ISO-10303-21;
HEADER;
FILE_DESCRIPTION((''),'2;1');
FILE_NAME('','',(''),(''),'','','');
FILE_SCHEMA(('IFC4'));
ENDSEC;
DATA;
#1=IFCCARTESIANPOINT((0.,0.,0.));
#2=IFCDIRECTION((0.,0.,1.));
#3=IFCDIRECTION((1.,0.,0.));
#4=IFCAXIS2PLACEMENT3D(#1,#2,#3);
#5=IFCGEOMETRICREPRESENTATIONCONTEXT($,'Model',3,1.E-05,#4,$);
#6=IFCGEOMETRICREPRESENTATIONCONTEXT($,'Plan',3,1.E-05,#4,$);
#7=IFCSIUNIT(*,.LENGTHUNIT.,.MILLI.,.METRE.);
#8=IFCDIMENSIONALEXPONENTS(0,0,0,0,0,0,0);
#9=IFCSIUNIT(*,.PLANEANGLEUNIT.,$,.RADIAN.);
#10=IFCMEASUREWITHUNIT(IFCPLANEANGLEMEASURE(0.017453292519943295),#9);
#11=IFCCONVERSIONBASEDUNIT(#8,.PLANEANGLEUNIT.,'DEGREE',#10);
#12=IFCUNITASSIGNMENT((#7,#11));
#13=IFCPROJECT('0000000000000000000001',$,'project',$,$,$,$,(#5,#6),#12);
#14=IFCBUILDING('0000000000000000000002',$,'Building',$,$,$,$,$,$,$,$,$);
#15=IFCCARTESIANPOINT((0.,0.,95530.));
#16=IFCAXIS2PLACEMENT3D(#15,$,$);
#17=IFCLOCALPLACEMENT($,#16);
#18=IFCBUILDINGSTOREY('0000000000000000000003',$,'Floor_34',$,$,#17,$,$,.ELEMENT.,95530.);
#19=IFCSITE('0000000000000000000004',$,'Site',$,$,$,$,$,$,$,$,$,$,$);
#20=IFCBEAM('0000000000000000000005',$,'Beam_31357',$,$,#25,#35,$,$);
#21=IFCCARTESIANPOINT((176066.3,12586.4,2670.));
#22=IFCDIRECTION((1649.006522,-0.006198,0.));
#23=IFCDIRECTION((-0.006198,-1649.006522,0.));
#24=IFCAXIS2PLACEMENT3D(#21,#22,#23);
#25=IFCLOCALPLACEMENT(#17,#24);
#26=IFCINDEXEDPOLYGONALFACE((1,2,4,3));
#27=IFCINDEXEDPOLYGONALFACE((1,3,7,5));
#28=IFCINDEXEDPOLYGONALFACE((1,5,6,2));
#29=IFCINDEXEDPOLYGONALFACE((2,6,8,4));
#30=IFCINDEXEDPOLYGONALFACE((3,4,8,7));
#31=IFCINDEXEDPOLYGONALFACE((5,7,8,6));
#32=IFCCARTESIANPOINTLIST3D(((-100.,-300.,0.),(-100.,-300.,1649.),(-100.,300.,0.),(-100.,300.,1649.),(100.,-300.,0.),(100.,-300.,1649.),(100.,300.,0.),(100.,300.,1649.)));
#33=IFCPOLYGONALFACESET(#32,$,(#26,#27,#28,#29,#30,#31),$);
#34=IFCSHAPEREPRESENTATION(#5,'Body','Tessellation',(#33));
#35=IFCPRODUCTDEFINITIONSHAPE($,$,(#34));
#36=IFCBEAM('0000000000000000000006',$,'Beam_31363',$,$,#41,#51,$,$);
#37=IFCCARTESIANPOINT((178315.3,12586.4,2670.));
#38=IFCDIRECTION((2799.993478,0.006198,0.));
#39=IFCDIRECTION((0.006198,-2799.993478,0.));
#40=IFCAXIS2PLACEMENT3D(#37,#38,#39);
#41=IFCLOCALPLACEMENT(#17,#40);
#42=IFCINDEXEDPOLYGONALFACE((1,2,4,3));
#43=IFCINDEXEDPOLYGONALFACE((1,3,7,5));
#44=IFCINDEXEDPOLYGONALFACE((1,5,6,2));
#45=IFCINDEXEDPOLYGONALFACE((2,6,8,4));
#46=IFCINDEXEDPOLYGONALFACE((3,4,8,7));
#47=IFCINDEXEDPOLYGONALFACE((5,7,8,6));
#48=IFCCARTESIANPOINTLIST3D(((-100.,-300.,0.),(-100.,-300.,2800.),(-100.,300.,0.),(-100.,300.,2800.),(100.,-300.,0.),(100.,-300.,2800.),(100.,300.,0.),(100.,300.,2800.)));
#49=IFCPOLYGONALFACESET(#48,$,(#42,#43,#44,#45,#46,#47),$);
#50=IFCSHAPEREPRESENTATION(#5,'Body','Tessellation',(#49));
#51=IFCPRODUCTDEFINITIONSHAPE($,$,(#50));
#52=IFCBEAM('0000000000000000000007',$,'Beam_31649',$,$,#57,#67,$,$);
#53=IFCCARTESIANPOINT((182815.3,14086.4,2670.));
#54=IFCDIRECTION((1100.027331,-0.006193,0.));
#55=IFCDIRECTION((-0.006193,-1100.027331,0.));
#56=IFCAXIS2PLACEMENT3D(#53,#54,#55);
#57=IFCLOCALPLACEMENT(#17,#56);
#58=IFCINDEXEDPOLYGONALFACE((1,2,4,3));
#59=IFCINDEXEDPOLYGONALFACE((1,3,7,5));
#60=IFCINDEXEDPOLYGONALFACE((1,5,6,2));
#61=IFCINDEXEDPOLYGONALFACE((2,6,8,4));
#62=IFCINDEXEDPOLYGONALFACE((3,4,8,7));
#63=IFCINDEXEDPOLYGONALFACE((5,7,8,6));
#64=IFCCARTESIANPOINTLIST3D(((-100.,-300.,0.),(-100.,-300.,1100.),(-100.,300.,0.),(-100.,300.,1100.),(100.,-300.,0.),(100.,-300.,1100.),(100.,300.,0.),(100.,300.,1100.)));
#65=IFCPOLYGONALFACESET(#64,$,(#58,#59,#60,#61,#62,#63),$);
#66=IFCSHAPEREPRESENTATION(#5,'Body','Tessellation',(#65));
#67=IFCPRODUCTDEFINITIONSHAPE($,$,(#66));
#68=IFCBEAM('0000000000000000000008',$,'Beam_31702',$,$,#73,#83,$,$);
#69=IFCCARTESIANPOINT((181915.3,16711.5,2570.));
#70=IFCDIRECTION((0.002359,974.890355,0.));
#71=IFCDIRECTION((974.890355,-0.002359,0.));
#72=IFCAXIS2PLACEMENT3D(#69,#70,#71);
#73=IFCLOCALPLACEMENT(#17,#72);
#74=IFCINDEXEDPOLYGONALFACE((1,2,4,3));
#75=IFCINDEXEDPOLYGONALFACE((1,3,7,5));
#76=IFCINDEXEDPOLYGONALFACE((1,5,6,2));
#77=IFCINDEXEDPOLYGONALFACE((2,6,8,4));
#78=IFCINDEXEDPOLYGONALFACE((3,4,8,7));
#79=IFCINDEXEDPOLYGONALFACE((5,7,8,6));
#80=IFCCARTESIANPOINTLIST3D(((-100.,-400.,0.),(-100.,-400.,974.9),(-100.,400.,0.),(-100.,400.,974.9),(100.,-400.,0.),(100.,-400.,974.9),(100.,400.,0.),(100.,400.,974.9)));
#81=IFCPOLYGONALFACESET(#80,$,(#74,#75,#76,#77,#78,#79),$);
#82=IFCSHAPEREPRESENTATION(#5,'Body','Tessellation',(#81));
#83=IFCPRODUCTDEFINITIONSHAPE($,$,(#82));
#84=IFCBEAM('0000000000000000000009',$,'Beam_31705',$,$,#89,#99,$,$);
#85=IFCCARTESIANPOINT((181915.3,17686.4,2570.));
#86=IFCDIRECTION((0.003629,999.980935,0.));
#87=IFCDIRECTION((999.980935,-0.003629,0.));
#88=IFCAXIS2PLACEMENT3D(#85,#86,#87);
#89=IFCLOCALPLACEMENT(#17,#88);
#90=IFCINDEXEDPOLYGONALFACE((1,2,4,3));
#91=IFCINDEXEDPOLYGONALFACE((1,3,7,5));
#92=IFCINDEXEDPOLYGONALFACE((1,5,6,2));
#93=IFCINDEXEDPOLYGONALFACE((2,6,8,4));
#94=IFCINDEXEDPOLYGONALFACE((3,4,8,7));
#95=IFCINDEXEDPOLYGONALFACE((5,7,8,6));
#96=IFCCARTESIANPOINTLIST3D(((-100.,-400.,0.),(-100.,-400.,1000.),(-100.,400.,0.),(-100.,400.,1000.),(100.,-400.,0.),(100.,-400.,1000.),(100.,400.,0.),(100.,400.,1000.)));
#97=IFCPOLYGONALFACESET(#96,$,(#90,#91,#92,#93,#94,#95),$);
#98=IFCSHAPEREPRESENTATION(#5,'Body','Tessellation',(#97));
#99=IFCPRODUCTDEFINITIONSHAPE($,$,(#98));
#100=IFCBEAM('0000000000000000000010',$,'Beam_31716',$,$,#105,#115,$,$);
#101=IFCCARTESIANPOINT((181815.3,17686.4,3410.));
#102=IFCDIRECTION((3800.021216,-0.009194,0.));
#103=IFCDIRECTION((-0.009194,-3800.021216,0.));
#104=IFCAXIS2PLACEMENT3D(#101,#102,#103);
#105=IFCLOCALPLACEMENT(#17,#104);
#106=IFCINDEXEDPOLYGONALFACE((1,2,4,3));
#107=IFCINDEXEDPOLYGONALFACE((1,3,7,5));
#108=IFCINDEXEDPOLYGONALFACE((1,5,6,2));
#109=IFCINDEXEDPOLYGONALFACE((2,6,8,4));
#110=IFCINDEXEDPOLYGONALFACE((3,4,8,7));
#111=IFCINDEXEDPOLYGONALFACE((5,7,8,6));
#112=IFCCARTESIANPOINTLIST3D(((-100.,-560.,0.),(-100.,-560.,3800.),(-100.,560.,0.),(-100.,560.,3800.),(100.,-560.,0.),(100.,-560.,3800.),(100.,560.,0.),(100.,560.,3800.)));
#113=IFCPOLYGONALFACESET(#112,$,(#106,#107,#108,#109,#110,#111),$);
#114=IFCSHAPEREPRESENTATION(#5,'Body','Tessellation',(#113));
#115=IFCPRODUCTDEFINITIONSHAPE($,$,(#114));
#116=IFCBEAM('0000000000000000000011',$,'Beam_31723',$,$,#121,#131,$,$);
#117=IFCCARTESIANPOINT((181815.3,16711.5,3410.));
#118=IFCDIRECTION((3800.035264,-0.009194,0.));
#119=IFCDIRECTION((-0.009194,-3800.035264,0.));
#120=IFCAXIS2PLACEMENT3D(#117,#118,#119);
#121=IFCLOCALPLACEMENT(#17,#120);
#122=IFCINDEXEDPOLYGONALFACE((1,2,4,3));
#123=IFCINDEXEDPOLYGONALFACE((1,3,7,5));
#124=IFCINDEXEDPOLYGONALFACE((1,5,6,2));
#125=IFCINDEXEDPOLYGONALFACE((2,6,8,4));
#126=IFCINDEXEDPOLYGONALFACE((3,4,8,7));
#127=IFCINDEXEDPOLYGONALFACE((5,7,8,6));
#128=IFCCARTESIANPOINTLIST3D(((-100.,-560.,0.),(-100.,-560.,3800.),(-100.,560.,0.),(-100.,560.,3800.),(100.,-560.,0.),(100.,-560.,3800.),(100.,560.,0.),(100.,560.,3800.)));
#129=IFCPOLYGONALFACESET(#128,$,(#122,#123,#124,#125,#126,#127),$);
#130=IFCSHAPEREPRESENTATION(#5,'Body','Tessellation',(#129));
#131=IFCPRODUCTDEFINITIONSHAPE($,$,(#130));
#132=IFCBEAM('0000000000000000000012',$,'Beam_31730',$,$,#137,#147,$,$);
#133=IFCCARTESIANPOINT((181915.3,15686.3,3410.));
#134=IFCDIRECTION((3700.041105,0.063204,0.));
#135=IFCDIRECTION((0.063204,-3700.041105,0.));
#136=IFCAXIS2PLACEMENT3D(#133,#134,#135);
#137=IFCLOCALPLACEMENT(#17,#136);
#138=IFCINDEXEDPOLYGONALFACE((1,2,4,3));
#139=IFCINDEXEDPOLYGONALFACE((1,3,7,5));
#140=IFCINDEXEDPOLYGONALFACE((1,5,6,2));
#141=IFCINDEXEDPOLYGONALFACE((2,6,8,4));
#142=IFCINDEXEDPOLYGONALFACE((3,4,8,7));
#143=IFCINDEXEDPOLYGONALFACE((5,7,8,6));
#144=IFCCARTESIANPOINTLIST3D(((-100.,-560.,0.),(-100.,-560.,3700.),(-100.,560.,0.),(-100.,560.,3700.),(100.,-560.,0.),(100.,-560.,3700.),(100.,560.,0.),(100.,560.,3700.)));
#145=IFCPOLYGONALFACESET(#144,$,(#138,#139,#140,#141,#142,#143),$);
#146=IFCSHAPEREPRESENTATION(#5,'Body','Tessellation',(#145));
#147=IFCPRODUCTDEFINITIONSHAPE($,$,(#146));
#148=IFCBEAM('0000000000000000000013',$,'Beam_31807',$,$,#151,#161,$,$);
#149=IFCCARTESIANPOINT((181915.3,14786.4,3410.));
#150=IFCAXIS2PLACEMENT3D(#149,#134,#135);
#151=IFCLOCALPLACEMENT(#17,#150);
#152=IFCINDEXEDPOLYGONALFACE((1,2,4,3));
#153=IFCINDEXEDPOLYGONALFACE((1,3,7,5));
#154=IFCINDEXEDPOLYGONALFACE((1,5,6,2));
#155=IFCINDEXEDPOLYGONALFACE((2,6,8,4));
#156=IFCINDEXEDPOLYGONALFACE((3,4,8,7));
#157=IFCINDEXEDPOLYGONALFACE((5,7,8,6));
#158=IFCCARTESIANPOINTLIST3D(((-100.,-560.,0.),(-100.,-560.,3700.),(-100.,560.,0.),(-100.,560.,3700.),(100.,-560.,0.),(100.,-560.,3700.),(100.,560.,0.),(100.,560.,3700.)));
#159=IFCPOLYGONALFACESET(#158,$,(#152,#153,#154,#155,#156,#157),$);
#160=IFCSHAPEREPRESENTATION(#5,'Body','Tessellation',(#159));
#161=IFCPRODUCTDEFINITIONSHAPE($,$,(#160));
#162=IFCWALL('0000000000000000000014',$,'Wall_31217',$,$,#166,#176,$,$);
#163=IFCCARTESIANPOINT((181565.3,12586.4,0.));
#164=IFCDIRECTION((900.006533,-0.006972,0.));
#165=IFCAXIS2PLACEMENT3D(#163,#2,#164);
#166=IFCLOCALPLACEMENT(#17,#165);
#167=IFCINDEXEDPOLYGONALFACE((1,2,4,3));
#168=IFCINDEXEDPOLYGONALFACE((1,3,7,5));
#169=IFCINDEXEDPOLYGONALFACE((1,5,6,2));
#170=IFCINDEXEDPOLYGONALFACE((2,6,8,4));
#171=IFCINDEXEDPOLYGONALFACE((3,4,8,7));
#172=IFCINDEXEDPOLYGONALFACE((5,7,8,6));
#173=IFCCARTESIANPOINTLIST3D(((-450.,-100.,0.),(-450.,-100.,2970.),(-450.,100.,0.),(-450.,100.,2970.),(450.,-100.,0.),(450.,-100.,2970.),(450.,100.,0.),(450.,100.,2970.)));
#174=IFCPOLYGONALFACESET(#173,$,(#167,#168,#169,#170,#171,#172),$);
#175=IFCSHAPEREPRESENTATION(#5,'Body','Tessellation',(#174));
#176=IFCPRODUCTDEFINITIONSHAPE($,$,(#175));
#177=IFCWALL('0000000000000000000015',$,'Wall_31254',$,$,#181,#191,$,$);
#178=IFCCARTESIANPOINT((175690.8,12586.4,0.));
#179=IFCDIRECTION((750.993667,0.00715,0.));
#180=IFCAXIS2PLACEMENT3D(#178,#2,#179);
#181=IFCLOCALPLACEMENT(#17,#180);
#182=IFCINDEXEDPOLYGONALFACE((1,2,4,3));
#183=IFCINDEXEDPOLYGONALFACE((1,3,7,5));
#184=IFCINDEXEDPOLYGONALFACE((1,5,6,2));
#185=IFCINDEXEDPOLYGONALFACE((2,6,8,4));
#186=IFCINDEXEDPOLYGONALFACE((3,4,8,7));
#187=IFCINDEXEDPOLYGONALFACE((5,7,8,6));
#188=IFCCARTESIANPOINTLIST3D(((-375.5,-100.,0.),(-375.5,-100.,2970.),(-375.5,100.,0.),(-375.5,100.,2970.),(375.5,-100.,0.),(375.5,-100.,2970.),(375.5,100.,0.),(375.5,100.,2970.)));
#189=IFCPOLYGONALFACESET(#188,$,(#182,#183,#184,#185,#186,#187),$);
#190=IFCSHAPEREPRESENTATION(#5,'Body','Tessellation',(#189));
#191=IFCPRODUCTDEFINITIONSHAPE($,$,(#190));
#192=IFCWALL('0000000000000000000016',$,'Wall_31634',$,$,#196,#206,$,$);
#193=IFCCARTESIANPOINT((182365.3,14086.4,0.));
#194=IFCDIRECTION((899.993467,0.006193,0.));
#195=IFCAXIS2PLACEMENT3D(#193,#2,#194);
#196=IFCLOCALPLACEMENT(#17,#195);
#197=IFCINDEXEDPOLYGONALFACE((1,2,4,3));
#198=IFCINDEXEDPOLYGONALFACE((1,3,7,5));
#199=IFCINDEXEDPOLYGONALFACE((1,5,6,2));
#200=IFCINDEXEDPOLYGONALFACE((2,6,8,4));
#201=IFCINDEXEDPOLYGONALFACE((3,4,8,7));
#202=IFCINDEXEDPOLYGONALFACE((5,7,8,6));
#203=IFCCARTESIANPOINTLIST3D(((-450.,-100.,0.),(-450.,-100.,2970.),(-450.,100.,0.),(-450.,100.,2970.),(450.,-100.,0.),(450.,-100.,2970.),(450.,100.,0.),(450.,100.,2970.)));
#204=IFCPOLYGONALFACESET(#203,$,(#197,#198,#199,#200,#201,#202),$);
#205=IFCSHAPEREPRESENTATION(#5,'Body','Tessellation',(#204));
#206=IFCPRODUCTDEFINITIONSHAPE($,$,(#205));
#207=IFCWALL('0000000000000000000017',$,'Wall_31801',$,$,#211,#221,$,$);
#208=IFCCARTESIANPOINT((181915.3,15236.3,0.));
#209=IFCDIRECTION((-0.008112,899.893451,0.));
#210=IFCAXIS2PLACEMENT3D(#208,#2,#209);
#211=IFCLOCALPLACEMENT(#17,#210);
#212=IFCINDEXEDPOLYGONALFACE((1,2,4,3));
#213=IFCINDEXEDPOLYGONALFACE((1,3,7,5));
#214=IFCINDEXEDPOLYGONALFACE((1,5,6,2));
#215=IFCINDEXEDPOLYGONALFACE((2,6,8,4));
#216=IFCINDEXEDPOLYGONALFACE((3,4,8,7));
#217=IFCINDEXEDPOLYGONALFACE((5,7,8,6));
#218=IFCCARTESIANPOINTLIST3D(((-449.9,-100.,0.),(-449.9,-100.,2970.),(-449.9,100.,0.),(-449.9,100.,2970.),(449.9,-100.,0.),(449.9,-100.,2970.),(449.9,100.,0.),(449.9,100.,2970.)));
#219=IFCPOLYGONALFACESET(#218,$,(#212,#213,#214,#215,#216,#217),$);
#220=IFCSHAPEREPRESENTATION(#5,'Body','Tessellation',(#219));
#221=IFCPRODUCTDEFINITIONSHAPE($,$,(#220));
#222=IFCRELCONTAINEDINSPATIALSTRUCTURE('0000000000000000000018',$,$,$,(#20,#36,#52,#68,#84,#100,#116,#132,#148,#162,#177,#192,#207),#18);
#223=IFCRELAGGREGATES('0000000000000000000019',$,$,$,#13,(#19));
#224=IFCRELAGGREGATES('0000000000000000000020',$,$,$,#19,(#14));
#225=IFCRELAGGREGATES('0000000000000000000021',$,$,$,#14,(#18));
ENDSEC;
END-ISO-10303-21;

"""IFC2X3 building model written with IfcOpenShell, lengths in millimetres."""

from ifc_helpers import new_model, entity, si_unit, converted_unit, frame, origin_with_axes, origin_2d, place, context, project, spatial, rectangle, extrude, element, save


model = new_model("IFC2X3")

# Units and contexts
model_context = context("Model", 3, precision=1e-05, world=origin_with_axes())
plan_context = context("Plan", 3, precision=1e-05, world=origin_with_axes())
ifc_project = project(units=[si_unit("LENGTHUNIT", "METRE", prefix="MILLI"), converted_unit("PLANEANGLEUNIT", "DEGREE", entity("IfcPlaneAngleMeasure", 0.017453292519943295), si_unit("PLANEANGLEUNIT", "RADIAN"), dimensions=[0, 0, 0, 0, 0, 0, 0])], contexts=[model_context, plan_context])

# Site, building, storey
site = spatial("IfcSite", under=ifc_project, Name="Site")
building = spatial("IfcBuilding", under=site, Name="Building")
storey_placement = place(None, frame((0.0, 0.0, 95530.0)))
storey = spatial("IfcBuildingStorey", under=building, at=storey_placement, Name="Floor_34", CompositionType="ELEMENT", Elevation=95530.0)

# Beams
beam_1_placement = place(storey_placement, frame((176066.3, 12586.4, 2670.0), z_axis=(1649.006522, -0.006198, 0.0), x_axis=(-0.006198, -1649.006522, 0.0)))
element("IfcBeam", 1, at=beam_1_placement, inside=storey, Name="Beam_31357", context=model_context, shape_type="SweptSolid", body=[
    extrude(rectangle(XDim=200.0, YDim=600.0, at=origin_2d()), origin_with_axes(), (0.0, 0.0, 1.0), 1649.0),
])
beam_2_placement = place(storey_placement, frame((178315.3, 12586.4, 2670.0), z_axis=(2799.993478, 0.006198, 0.0), x_axis=(0.006198, -2799.993478, 0.0)))
element("IfcBeam", 2, at=beam_2_placement, inside=storey, Name="Beam_31363", context=model_context, shape_type="SweptSolid", body=[
    extrude(rectangle(XDim=200.0, YDim=600.0, at=origin_2d()), origin_with_axes(), (0.0, 0.0, 1.0), 2800.0),
])
beam_3_placement = place(storey_placement, frame((182815.3, 14086.4, 2670.0), z_axis=(1100.027331, -0.006193, 0.0), x_axis=(-0.006193, -1100.027331, 0.0)))
element("IfcBeam", 3, at=beam_3_placement, inside=storey, Name="Beam_31649", context=model_context, shape_type="SweptSolid", body=[
    extrude(rectangle(XDim=200.0, YDim=600.0, at=origin_2d()), origin_with_axes(), (0.0, 0.0, 1.0), 1100.0),
])
beam_4_placement = place(storey_placement, frame((181915.3, 16711.5, 2570.0), z_axis=(0.002359, 974.890355, 0.0), x_axis=(974.890355, -0.002359, 0.0)))
element("IfcBeam", 4, at=beam_4_placement, inside=storey, Name="Beam_31702", context=model_context, shape_type="SweptSolid", body=[
    extrude(rectangle(XDim=200.0, YDim=800.0, at=origin_2d()), origin_with_axes(), (0.0, 0.0, 1.0), 974.9),
])
beam_5_placement = place(storey_placement, frame((181915.3, 17686.4, 2570.0), z_axis=(0.003629, 999.980935, 0.0), x_axis=(999.980935, -0.003629, 0.0)))
element("IfcBeam", 5, at=beam_5_placement, inside=storey, Name="Beam_31705", context=model_context, shape_type="SweptSolid", body=[
    extrude(rectangle(XDim=200.0, YDim=800.0, at=origin_2d()), origin_with_axes(), (0.0, 0.0, 1.0), 1000.0),
])
beam_6_placement = place(storey_placement, frame((181815.3, 17686.4, 3410.0), z_axis=(3800.021216, -0.009194, 0.0), x_axis=(-0.009194, -3800.021216, 0.0)))
element("IfcBeam", 6, at=beam_6_placement, inside=storey, Name="Beam_31716", context=model_context, shape_type="SweptSolid", body=[
    extrude(rectangle(XDim=200.0, YDim=1120.0, at=origin_2d()), origin_with_axes(), (0.0, 0.0, 1.0), 3800.0),
])
beam_7_placement = place(storey_placement, frame((181815.3, 16711.5, 3410.0), z_axis=(3800.035264, -0.009194, 0.0), x_axis=(-0.009194, -3800.035264, 0.0)))
element("IfcBeam", 7, at=beam_7_placement, inside=storey, Name="Beam_31723", context=model_context, shape_type="SweptSolid", body=[
    extrude(rectangle(XDim=200.0, YDim=1120.0, at=origin_2d()), origin_with_axes(), (0.0, 0.0, 1.0), 3800.0),
])
beam_8_placement = place(storey_placement, frame((181915.3, 15686.3, 3410.0), z_axis=(3700.041105, 0.063204, 0.0), x_axis=(0.063204, -3700.041105, 0.0)))
element("IfcBeam", 8, at=beam_8_placement, inside=storey, Name="Beam_31730", context=model_context, shape_type="SweptSolid", body=[
    extrude(rectangle(XDim=200.0, YDim=1120.0, at=origin_2d()), origin_with_axes(), (0.0, 0.0, 1.0), 3700.0),
])
beam_9_placement = place(storey_placement, frame((181915.3, 14786.4, 3410.0), z_axis=(3700.041105, 0.063204, 0.0), x_axis=(0.063204, -3700.041105, 0.0)))
element("IfcBeam", 9, at=beam_9_placement, inside=storey, Name="Beam_31807", context=model_context, shape_type="SweptSolid", body=[
    extrude(rectangle(XDim=200.0, YDim=1120.0, at=origin_2d()), origin_with_axes(), (0.0, 0.0, 1.0), 3700.0),
])

# Walls
wall_1_placement = place(storey_placement, frame((181565.3, 12586.4, 0.0), z_axis=(0.0, 0.0, 1.0), x_axis=(900.006533, -0.006972, 0.0)))
element("IfcWall", 10, at=wall_1_placement, inside=storey, Name="Wall_31217", context=model_context, shape_type="SweptSolid", body=[
    extrude(rectangle(XDim=900.0, YDim=200.0, at=origin_2d()), origin_with_axes(), (0.0, 0.0, 1.0), 2970.0),
])
wall_2_placement = place(storey_placement, frame((175690.8, 12586.4, 0.0), z_axis=(0.0, 0.0, 1.0), x_axis=(750.993667, 0.00715, 0.0)))
element("IfcWall", 11, at=wall_2_placement, inside=storey, Name="Wall_31254", context=model_context, shape_type="SweptSolid", body=[
    extrude(rectangle(XDim=751.0, YDim=200.0, at=origin_2d()), origin_with_axes(), (0.0, 0.0, 1.0), 2970.0),
])
wall_3_placement = place(storey_placement, frame((182365.3, 14086.4, 0.0), z_axis=(0.0, 0.0, 1.0), x_axis=(899.993467, 0.006193, 0.0)))
element("IfcWall", 12, at=wall_3_placement, inside=storey, Name="Wall_31634", context=model_context, shape_type="SweptSolid", body=[
    extrude(rectangle(XDim=900.0, YDim=200.0, at=origin_2d()), origin_with_axes(), (0.0, 0.0, 1.0), 2970.0),
])
wall_4_placement = place(storey_placement, frame((181915.3, 15236.3, 0.0), z_axis=(0.0, 0.0, 1.0), x_axis=(-0.008112, 899.893451, 0.0)))
element("IfcWall", 13, at=wall_4_placement, inside=storey, Name="Wall_31801", context=model_context, shape_type="SweptSolid", body=[
    extrude(rectangle(XDim=899.9, YDim=200.0, at=origin_2d()), origin_with_axes(), (0.0, 0.0, 1.0), 2970.0),
])

save(model, "model.ifc")
